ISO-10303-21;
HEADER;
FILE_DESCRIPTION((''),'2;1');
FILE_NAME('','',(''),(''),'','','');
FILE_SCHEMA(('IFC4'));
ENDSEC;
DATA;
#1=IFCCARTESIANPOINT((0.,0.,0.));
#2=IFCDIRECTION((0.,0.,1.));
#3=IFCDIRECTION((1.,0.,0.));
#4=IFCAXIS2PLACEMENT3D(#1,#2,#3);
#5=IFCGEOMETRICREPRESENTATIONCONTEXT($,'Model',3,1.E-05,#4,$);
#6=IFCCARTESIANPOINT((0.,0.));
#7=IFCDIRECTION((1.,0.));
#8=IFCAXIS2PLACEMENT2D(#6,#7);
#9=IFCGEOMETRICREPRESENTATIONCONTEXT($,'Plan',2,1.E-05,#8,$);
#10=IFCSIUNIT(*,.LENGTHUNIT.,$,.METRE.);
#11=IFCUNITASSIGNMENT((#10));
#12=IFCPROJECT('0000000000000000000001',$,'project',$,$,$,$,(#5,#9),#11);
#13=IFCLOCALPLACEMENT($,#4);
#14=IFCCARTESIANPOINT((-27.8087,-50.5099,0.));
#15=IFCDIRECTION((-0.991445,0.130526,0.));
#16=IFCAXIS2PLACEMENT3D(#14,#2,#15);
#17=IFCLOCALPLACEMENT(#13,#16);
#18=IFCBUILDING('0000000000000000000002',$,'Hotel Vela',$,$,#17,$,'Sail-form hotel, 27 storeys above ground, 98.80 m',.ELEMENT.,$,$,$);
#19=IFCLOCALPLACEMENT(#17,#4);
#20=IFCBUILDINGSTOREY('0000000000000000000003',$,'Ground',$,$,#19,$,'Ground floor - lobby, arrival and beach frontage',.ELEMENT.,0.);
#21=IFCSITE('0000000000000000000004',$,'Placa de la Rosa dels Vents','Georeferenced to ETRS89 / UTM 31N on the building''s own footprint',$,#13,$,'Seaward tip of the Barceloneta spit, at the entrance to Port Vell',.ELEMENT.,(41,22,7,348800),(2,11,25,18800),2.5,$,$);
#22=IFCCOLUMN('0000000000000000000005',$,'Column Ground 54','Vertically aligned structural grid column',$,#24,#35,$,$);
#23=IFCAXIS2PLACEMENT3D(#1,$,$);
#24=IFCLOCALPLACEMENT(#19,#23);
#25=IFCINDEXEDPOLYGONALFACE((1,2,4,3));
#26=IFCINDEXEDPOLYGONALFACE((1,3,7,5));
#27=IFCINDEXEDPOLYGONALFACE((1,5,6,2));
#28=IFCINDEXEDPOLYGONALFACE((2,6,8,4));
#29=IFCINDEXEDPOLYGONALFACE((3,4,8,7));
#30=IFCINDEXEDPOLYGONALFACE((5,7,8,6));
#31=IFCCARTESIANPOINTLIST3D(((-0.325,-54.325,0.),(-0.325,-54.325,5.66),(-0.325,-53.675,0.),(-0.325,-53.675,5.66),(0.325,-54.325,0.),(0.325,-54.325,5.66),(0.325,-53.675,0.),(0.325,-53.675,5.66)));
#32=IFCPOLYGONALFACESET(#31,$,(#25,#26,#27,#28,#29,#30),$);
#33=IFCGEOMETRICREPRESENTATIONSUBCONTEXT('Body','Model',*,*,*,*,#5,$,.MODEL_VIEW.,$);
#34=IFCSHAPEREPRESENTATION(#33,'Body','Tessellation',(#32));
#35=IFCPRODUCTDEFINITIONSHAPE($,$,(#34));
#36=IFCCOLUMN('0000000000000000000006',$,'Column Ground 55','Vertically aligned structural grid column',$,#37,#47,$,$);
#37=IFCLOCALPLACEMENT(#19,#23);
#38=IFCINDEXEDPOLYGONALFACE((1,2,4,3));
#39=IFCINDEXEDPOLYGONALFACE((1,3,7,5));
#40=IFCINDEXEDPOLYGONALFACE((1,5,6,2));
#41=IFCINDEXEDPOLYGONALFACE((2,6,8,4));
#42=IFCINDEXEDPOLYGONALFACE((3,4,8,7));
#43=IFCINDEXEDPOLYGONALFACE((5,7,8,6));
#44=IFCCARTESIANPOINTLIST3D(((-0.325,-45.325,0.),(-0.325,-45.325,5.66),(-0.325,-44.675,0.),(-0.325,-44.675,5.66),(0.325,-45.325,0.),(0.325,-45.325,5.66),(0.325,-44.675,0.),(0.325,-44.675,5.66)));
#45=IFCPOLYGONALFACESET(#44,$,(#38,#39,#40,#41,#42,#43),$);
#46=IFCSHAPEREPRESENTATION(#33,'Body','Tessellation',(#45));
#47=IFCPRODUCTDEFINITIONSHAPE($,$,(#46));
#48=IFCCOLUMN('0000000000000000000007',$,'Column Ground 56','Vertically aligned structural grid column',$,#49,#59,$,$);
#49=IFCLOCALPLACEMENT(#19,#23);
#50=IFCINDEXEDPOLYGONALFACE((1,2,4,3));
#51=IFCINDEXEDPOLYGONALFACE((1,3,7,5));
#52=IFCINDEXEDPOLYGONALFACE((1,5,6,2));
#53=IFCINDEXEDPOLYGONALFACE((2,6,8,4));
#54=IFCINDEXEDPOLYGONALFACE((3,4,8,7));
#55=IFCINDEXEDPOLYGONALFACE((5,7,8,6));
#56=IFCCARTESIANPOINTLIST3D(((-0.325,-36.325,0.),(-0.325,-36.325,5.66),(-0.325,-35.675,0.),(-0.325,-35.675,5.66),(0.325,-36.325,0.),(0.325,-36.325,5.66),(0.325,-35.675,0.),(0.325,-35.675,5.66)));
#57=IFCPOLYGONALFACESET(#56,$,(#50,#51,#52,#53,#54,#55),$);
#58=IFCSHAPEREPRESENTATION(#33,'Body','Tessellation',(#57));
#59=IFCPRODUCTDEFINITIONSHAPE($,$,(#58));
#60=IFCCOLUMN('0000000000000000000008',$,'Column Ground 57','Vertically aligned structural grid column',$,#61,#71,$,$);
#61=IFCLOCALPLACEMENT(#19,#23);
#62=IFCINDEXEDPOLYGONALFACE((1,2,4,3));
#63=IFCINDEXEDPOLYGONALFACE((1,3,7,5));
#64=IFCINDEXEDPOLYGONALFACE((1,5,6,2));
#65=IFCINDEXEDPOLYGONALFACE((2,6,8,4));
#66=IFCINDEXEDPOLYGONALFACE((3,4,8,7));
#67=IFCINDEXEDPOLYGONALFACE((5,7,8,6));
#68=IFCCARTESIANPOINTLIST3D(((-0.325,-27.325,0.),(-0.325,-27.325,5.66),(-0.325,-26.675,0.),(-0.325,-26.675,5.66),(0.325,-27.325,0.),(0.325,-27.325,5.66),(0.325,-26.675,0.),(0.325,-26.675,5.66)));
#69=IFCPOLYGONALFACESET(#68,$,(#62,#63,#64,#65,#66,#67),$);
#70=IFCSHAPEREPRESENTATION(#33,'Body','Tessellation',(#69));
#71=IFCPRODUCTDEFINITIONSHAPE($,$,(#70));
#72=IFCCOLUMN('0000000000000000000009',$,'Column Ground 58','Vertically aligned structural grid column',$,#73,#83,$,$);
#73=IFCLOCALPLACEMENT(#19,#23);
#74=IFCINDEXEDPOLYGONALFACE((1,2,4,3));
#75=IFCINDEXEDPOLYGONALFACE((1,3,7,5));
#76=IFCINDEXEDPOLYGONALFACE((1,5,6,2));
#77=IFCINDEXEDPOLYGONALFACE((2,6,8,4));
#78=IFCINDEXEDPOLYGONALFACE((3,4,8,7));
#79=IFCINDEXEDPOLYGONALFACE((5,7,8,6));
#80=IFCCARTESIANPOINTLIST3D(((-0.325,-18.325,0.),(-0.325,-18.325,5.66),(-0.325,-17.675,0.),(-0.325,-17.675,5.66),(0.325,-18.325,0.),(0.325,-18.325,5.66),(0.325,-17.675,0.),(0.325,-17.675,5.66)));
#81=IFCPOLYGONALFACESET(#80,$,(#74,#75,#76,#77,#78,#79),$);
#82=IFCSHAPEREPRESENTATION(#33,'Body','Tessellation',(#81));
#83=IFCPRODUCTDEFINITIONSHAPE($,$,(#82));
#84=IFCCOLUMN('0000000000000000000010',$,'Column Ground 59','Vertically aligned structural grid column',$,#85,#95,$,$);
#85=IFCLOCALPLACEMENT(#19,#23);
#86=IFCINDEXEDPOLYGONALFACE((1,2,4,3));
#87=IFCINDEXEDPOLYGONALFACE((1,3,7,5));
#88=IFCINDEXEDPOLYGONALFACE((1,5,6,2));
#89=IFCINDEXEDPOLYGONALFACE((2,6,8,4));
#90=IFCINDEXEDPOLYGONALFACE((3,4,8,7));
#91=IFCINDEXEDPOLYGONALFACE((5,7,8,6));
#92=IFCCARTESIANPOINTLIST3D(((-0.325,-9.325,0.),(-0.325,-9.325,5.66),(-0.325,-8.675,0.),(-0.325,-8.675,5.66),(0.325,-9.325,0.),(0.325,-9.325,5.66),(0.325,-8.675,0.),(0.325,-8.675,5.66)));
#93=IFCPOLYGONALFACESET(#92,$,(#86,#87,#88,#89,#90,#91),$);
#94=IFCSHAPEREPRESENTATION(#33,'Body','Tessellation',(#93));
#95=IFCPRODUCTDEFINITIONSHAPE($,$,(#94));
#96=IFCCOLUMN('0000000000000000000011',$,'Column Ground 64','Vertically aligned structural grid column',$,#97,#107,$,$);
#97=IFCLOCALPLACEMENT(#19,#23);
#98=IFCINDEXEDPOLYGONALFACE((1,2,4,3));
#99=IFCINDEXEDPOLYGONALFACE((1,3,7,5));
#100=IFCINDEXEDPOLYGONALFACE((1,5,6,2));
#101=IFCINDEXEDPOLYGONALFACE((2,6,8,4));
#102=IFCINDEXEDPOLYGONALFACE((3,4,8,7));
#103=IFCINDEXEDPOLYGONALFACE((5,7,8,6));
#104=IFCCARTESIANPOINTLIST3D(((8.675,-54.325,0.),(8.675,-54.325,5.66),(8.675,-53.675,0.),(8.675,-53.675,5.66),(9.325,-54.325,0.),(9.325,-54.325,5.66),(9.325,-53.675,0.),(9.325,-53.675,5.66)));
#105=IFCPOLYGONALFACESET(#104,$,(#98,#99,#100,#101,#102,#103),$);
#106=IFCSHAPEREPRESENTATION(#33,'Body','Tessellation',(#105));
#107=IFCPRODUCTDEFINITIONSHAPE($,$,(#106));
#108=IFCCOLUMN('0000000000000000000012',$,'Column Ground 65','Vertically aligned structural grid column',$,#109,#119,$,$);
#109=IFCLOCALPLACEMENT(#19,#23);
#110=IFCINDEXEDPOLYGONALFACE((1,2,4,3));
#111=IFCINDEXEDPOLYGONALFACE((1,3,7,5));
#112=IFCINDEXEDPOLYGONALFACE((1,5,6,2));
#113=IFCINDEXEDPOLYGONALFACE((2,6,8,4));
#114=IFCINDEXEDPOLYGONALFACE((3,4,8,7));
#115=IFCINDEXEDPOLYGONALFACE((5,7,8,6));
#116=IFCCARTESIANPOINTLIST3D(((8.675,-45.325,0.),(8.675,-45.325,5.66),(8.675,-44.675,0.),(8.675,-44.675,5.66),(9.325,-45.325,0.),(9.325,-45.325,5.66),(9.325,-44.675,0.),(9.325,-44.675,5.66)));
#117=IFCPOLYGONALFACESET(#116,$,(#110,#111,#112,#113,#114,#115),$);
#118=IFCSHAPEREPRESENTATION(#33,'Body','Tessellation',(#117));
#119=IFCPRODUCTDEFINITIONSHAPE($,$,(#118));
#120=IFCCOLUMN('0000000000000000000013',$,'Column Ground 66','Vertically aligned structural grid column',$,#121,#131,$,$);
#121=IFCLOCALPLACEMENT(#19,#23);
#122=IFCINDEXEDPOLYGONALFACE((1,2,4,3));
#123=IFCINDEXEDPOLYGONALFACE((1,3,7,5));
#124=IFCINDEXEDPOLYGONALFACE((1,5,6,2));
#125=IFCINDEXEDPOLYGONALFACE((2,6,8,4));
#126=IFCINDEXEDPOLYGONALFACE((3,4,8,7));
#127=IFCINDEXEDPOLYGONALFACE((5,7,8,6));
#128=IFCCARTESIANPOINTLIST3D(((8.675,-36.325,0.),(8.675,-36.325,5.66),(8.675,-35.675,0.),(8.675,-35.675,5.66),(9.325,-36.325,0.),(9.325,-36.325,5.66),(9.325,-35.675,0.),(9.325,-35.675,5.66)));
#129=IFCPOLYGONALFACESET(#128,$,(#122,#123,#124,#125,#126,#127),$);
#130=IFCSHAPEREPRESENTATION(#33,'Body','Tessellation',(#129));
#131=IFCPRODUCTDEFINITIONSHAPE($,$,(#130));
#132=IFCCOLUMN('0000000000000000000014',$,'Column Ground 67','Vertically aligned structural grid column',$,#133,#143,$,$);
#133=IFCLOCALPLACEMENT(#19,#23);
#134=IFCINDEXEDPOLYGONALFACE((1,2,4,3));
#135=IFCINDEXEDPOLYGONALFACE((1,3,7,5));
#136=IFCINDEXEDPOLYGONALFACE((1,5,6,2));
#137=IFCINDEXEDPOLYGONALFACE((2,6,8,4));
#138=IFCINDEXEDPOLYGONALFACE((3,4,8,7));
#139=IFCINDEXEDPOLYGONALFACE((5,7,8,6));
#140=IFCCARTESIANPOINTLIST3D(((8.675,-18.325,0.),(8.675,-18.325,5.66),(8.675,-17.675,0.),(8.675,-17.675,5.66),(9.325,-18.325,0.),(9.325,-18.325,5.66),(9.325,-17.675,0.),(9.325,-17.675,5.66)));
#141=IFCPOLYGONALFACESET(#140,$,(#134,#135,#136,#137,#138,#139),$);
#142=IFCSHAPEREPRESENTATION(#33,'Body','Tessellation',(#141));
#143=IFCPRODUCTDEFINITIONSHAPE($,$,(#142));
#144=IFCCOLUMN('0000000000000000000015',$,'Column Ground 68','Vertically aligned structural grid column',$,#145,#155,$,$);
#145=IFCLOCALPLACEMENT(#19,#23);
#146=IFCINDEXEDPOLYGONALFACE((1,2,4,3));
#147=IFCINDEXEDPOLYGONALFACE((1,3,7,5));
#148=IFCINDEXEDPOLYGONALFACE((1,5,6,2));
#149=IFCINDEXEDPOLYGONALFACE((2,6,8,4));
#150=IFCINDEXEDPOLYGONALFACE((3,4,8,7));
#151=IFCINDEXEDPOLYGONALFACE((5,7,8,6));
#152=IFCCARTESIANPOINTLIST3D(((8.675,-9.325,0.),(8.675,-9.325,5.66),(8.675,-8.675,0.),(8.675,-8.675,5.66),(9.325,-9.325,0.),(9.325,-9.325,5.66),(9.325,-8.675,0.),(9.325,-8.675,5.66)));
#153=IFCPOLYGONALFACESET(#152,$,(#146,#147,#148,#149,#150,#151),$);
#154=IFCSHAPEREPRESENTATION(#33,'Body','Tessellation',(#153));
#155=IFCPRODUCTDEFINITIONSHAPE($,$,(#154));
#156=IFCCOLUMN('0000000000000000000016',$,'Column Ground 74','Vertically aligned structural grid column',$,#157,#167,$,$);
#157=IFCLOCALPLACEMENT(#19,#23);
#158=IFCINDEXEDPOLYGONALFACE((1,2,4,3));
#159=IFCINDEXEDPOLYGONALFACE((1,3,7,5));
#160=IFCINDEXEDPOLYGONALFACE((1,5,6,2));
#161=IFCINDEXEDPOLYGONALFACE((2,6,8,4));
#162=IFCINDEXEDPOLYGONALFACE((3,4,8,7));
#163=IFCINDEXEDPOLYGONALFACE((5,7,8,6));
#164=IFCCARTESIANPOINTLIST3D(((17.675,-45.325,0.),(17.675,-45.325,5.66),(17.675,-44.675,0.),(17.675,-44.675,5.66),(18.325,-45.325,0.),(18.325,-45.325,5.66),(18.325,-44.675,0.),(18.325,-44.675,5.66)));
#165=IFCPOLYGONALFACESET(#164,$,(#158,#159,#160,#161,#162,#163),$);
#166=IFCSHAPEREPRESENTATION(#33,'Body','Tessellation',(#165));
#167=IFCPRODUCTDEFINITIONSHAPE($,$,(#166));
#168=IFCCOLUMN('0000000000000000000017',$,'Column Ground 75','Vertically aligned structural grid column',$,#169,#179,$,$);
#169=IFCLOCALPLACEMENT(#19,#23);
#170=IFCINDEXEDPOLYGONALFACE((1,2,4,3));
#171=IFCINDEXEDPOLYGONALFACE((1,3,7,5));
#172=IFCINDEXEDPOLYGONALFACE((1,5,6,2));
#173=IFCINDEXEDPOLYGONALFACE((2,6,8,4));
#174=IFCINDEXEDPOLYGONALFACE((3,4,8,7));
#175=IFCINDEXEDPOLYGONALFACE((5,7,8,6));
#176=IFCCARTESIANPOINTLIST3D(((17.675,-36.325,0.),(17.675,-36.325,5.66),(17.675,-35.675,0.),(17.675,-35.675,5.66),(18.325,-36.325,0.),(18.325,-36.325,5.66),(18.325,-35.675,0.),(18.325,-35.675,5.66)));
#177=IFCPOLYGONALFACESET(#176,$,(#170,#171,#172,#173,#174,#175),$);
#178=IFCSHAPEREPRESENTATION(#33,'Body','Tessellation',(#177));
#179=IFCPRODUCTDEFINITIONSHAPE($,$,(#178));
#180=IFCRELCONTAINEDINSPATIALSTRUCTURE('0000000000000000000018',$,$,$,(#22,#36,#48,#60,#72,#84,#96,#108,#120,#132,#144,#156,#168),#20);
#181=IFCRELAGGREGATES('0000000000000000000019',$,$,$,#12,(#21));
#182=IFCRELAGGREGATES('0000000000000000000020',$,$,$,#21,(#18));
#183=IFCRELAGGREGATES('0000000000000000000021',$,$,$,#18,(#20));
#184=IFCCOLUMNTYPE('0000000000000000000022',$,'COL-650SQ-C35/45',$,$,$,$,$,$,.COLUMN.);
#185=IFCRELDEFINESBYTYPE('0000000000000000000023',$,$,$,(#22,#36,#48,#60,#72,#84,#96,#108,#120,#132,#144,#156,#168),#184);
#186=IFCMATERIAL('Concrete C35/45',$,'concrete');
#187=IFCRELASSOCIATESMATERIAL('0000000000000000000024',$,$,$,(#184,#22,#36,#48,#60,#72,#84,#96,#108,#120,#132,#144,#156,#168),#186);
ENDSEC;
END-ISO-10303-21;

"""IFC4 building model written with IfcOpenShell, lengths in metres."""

from ifc_helpers import new_model, si_unit, frame, origin_with_axes, origin_2d_with_axis, place, context, subcontext, project, spatial, line, indexed_curve, rectangle, outline, extrude, material, material_profile, profile_set, profile_usage, type_object, element, save


model = new_model("IFC4")

# Units and contexts
model_context = context("Model", 3, precision=1e-05, world=origin_with_axes())
plan_context = context("Plan", 2, precision=1e-05, world=origin_2d_with_axis())
body_context = subcontext(model_context, "Body", "Model", "MODEL_VIEW")
ifc_project = project(units=[si_unit("LENGTHUNIT", "METRE")], contexts=[model_context, plan_context])

# Site, building, storey
site_placement = place(None, origin_with_axes())
site = spatial("IfcSite", under=ifc_project, at=site_placement, Name="Placa de la Rosa dels Vents", Description="Georeferenced to ETRS89 / UTM 31N on the building's own footprint", LongName="Seaward tip of the Barceloneta spit, at the entrance to Port Vell", CompositionType="ELEMENT", RefLatitude=(41, 22, 7, 348800), RefLongitude=(2, 11, 25, 18800), RefElevation=2.5)
building_placement = place(site_placement, frame((-27.8087, -50.5099, 0.0), z_axis=(0.0, 0.0, 1.0), x_axis=(-0.991445, 0.130526, 0.0)))
building = spatial("IfcBuilding", under=site, at=building_placement, Name="Hotel Vela", LongName="Sail-form hotel, 27 storeys above ground, 98.80 m", CompositionType="ELEMENT")
storey_placement = place(building_placement, origin_with_axes())
storey = spatial("IfcBuildingStorey", under=building, at=storey_placement, Name="Ground", LongName="Ground floor - lobby, arrival and beach frontage", CompositionType="ELEMENT", Elevation=0.0)

# Columns
ifc_material = material(Name="Concrete C35/45", Category="concrete")
ifc_material_profile = material_profile(ifc_material, rectangle(XDim=0.65, YDim=0.65))
ifc_profile_set = profile_set([ifc_material_profile], Name="COL-650SQ-C35/45")
ifc_profile_usage_1 = profile_usage(ifc_profile_set)
column_type = type_object("IfcColumnType", Name="COL-650SQ-C35/45", PredefinedType="COLUMN", material=ifc_profile_set)
column_1_placement = place(storey_placement, frame((-0.325, -54.325, 0.0), z_axis=(0.0, 0.0, 1.0), x_axis=(1.0, 0.0, 0.0)))
element("IfcColumn", 1, at=column_1_placement, inside=storey, type_object=column_type, material=ifc_profile_usage_1, Name="Column Ground 54", Description="Vertically aligned structural grid column", context=body_context, shape_type="SweptSolid", body=[
    extrude(outline(indexed_curve([(0.0, 0.0), (0.65, 0.0), (0.65, 0.65), (0.0, 0.65)], segments=[line(1, 2, 3, 4, 1)])), origin_with_axes(), (0.0, 0.0, 1.0), 5.66),
])
ifc_profile_usage_2 = profile_usage(ifc_profile_set)
column_2_placement = place(storey_placement, frame((-0.325, -45.325, 0.0), z_axis=(0.0, 0.0, 1.0), x_axis=(1.0, 0.0, 0.0)))
element("IfcColumn", 2, at=column_2_placement, inside=storey, type_object=column_type, material=ifc_profile_usage_2, Name="Column Ground 55", Description="Vertically aligned structural grid column", context=body_context, shape_type="SweptSolid", body=[
    extrude(outline(indexed_curve([(0.0, 0.0), (0.65, 0.0), (0.65, 0.65), (0.0, 0.65)], segments=[line(1, 2, 3, 4, 1)])), origin_with_axes(), (0.0, 0.0, 1.0), 5.66),
])
ifc_profile_usage_3 = profile_usage(ifc_profile_set)
column_3_placement = place(storey_placement, frame((-0.325, -36.325, 0.0), z_axis=(0.0, 0.0, 1.0), x_axis=(1.0, 0.0, 0.0)))
element("IfcColumn", 3, at=column_3_placement, inside=storey, type_object=column_type, material=ifc_profile_usage_3, Name="Column Ground 56", Description="Vertically aligned structural grid column", context=body_context, shape_type="SweptSolid", body=[
    extrude(outline(indexed_curve([(0.0, 0.0), (0.65, 0.0), (0.65, 0.65), (0.0, 0.65)], segments=[line(1, 2, 3, 4, 1)])), origin_with_axes(), (0.0, 0.0, 1.0), 5.66),
])
ifc_profile_usage_4 = profile_usage(ifc_profile_set)
column_4_placement = place(storey_placement, frame((-0.325, -27.325, 0.0), z_axis=(0.0, 0.0, 1.0), x_axis=(1.0, 0.0, 0.0)))
element("IfcColumn", 4, at=column_4_placement, inside=storey, type_object=column_type, material=ifc_profile_usage_4, Name="Column Ground 57", Description="Vertically aligned structural grid column", context=body_context, shape_type="SweptSolid", body=[
    extrude(outline(indexed_curve([(0.0, 0.0), (0.65, 0.0), (0.65, 0.65), (0.0, 0.65)], segments=[line(1, 2, 3, 4, 1)])), origin_with_axes(), (0.0, 0.0, 1.0), 5.66),
])
ifc_profile_usage_5 = profile_usage(ifc_profile_set)
column_5_placement = place(storey_placement, frame((-0.325, -18.325, 0.0), z_axis=(0.0, 0.0, 1.0), x_axis=(1.0, 0.0, 0.0)))
element("IfcColumn", 5, at=column_5_placement, inside=storey, type_object=column_type, material=ifc_profile_usage_5, Name="Column Ground 58", Description="Vertically aligned structural grid column", context=body_context, shape_type="SweptSolid", body=[
    extrude(outline(indexed_curve([(0.0, 0.0), (0.65, 0.0), (0.65, 0.65), (0.0, 0.65)], segments=[line(1, 2, 3, 4, 1)])), origin_with_axes(), (0.0, 0.0, 1.0), 5.66),
])
ifc_profile_usage_6 = profile_usage(ifc_profile_set)
column_6_placement = place(storey_placement, frame((-0.325, -9.325, 0.0), z_axis=(0.0, 0.0, 1.0), x_axis=(1.0, 0.0, 0.0)))
element("IfcColumn", 6, at=column_6_placement, inside=storey, type_object=column_type, material=ifc_profile_usage_6, Name="Column Ground 59", Description="Vertically aligned structural grid column", context=body_context, shape_type="SweptSolid", body=[
    extrude(outline(indexed_curve([(0.0, 0.0), (0.65, 0.0), (0.65, 0.65), (0.0, 0.65)], segments=[line(1, 2, 3, 4, 1)])), origin_with_axes(), (0.0, 0.0, 1.0), 5.66),
])
ifc_profile_usage_7 = profile_usage(ifc_profile_set)
column_7_placement = place(storey_placement, frame((8.675, -54.325, 0.0), z_axis=(0.0, 0.0, 1.0), x_axis=(1.0, 0.0, 0.0)))
element("IfcColumn", 7, at=column_7_placement, inside=storey, type_object=column_type, material=ifc_profile_usage_7, Name="Column Ground 64", Description="Vertically aligned structural grid column", context=body_context, shape_type="SweptSolid", body=[
    extrude(outline(indexed_curve([(0.0, 0.0), (0.65, 0.0), (0.65, 0.65), (0.0, 0.65)], segments=[line(1, 2, 3, 4, 1)])), origin_with_axes(), (0.0, 0.0, 1.0), 5.66),
])
ifc_profile_usage_8 = profile_usage(ifc_profile_set)
column_8_placement = place(storey_placement, frame((8.675, -45.325, 0.0), z_axis=(0.0, 0.0, 1.0), x_axis=(1.0, 0.0, 0.0)))
element("IfcColumn", 8, at=column_8_placement, inside=storey, type_object=column_type, material=ifc_profile_usage_8, Name="Column Ground 65", Description="Vertically aligned structural grid column", context=body_context, shape_type="SweptSolid", body=[
    extrude(outline(indexed_curve([(0.0, 0.0), (0.65, 0.0), (0.65, 0.65), (0.0, 0.65)], segments=[line(1, 2, 3, 4, 1)])), origin_with_axes(), (0.0, 0.0, 1.0), 5.66),
])
ifc_profile_usage_9 = profile_usage(ifc_profile_set)
column_9_placement = place(storey_placement, frame((8.675, -36.325, 0.0), z_axis=(0.0, 0.0, 1.0), x_axis=(1.0, 0.0, 0.0)))
element("IfcColumn", 9, at=column_9_placement, inside=storey, type_object=column_type, material=ifc_profile_usage_9, Name="Column Ground 66", Description="Vertically aligned structural grid column", context=body_context, shape_type="SweptSolid", body=[
    extrude(outline(indexed_curve([(0.0, 0.0), (0.65, 0.0), (0.65, 0.65), (0.0, 0.65)], segments=[line(1, 2, 3, 4, 1)])), origin_with_axes(), (0.0, 0.0, 1.0), 5.66),
])
ifc_profile_usage_10 = profile_usage(ifc_profile_set)
column_10_placement = place(storey_placement, frame((8.675, -18.325, 0.0), z_axis=(0.0, 0.0, 1.0), x_axis=(1.0, 0.0, 0.0)))
element("IfcColumn", 10, at=column_10_placement, inside=storey, type_object=column_type, material=ifc_profile_usage_10, Name="Column Ground 67", Description="Vertically aligned structural grid column", context=body_context, shape_type="SweptSolid", body=[
    extrude(outline(indexed_curve([(0.0, 0.0), (0.65, 0.0), (0.65, 0.65), (0.0, 0.65)], segments=[line(1, 2, 3, 4, 1)])), origin_with_axes(), (0.0, 0.0, 1.0), 5.66),
])
ifc_profile_usage_11 = profile_usage(ifc_profile_set)
column_11_placement = place(storey_placement, frame((8.675, -9.325, 0.0), z_axis=(0.0, 0.0, 1.0), x_axis=(1.0, 0.0, 0.0)))
element("IfcColumn", 11, at=column_11_placement, inside=storey, type_object=column_type, material=ifc_profile_usage_11, Name="Column Ground 68", Description="Vertically aligned structural grid column", context=body_context, shape_type="SweptSolid", body=[
    extrude(outline(indexed_curve([(0.0, 0.0), (0.65, 0.0), (0.65, 0.65), (0.0, 0.65)], segments=[line(1, 2, 3, 4, 1)])), origin_with_axes(), (0.0, 0.0, 1.0), 5.66),
])
ifc_profile_usage_12 = profile_usage(ifc_profile_set)
column_12_placement = place(storey_placement, frame((17.675, -45.325, 0.0), z_axis=(0.0, 0.0, 1.0), x_axis=(1.0, 0.0, 0.0)))
element("IfcColumn", 12, at=column_12_placement, inside=storey, type_object=column_type, material=ifc_profile_usage_12, Name="Column Ground 74", Description="Vertically aligned structural grid column", context=body_context, shape_type="SweptSolid", body=[
    extrude(outline(indexed_curve([(0.0, 0.0), (0.65, 0.0), (0.65, 0.65), (0.0, 0.65)], segments=[line(1, 2, 3, 4, 1)])), origin_with_axes(), (0.0, 0.0, 1.0), 5.66),
])
ifc_profile_usage_13 = profile_usage(ifc_profile_set)
column_13_placement = place(storey_placement, frame((17.675, -36.325, 0.0), z_axis=(0.0, 0.0, 1.0), x_axis=(1.0, 0.0, 0.0)))
element("IfcColumn", 13, at=column_13_placement, inside=storey, type_object=column_type, material=ifc_profile_usage_13, Name="Column Ground 75", Description="Vertically aligned structural grid column", context=body_context, shape_type="SweptSolid", body=[
    extrude(outline(indexed_curve([(0.0, 0.0), (0.65, 0.0), (0.65, 0.65), (0.0, 0.65)], segments=[line(1, 2, 3, 4, 1)])), origin_with_axes(), (0.0, 0.0, 1.0), 5.66),
])

save(model, "model.ifc")
